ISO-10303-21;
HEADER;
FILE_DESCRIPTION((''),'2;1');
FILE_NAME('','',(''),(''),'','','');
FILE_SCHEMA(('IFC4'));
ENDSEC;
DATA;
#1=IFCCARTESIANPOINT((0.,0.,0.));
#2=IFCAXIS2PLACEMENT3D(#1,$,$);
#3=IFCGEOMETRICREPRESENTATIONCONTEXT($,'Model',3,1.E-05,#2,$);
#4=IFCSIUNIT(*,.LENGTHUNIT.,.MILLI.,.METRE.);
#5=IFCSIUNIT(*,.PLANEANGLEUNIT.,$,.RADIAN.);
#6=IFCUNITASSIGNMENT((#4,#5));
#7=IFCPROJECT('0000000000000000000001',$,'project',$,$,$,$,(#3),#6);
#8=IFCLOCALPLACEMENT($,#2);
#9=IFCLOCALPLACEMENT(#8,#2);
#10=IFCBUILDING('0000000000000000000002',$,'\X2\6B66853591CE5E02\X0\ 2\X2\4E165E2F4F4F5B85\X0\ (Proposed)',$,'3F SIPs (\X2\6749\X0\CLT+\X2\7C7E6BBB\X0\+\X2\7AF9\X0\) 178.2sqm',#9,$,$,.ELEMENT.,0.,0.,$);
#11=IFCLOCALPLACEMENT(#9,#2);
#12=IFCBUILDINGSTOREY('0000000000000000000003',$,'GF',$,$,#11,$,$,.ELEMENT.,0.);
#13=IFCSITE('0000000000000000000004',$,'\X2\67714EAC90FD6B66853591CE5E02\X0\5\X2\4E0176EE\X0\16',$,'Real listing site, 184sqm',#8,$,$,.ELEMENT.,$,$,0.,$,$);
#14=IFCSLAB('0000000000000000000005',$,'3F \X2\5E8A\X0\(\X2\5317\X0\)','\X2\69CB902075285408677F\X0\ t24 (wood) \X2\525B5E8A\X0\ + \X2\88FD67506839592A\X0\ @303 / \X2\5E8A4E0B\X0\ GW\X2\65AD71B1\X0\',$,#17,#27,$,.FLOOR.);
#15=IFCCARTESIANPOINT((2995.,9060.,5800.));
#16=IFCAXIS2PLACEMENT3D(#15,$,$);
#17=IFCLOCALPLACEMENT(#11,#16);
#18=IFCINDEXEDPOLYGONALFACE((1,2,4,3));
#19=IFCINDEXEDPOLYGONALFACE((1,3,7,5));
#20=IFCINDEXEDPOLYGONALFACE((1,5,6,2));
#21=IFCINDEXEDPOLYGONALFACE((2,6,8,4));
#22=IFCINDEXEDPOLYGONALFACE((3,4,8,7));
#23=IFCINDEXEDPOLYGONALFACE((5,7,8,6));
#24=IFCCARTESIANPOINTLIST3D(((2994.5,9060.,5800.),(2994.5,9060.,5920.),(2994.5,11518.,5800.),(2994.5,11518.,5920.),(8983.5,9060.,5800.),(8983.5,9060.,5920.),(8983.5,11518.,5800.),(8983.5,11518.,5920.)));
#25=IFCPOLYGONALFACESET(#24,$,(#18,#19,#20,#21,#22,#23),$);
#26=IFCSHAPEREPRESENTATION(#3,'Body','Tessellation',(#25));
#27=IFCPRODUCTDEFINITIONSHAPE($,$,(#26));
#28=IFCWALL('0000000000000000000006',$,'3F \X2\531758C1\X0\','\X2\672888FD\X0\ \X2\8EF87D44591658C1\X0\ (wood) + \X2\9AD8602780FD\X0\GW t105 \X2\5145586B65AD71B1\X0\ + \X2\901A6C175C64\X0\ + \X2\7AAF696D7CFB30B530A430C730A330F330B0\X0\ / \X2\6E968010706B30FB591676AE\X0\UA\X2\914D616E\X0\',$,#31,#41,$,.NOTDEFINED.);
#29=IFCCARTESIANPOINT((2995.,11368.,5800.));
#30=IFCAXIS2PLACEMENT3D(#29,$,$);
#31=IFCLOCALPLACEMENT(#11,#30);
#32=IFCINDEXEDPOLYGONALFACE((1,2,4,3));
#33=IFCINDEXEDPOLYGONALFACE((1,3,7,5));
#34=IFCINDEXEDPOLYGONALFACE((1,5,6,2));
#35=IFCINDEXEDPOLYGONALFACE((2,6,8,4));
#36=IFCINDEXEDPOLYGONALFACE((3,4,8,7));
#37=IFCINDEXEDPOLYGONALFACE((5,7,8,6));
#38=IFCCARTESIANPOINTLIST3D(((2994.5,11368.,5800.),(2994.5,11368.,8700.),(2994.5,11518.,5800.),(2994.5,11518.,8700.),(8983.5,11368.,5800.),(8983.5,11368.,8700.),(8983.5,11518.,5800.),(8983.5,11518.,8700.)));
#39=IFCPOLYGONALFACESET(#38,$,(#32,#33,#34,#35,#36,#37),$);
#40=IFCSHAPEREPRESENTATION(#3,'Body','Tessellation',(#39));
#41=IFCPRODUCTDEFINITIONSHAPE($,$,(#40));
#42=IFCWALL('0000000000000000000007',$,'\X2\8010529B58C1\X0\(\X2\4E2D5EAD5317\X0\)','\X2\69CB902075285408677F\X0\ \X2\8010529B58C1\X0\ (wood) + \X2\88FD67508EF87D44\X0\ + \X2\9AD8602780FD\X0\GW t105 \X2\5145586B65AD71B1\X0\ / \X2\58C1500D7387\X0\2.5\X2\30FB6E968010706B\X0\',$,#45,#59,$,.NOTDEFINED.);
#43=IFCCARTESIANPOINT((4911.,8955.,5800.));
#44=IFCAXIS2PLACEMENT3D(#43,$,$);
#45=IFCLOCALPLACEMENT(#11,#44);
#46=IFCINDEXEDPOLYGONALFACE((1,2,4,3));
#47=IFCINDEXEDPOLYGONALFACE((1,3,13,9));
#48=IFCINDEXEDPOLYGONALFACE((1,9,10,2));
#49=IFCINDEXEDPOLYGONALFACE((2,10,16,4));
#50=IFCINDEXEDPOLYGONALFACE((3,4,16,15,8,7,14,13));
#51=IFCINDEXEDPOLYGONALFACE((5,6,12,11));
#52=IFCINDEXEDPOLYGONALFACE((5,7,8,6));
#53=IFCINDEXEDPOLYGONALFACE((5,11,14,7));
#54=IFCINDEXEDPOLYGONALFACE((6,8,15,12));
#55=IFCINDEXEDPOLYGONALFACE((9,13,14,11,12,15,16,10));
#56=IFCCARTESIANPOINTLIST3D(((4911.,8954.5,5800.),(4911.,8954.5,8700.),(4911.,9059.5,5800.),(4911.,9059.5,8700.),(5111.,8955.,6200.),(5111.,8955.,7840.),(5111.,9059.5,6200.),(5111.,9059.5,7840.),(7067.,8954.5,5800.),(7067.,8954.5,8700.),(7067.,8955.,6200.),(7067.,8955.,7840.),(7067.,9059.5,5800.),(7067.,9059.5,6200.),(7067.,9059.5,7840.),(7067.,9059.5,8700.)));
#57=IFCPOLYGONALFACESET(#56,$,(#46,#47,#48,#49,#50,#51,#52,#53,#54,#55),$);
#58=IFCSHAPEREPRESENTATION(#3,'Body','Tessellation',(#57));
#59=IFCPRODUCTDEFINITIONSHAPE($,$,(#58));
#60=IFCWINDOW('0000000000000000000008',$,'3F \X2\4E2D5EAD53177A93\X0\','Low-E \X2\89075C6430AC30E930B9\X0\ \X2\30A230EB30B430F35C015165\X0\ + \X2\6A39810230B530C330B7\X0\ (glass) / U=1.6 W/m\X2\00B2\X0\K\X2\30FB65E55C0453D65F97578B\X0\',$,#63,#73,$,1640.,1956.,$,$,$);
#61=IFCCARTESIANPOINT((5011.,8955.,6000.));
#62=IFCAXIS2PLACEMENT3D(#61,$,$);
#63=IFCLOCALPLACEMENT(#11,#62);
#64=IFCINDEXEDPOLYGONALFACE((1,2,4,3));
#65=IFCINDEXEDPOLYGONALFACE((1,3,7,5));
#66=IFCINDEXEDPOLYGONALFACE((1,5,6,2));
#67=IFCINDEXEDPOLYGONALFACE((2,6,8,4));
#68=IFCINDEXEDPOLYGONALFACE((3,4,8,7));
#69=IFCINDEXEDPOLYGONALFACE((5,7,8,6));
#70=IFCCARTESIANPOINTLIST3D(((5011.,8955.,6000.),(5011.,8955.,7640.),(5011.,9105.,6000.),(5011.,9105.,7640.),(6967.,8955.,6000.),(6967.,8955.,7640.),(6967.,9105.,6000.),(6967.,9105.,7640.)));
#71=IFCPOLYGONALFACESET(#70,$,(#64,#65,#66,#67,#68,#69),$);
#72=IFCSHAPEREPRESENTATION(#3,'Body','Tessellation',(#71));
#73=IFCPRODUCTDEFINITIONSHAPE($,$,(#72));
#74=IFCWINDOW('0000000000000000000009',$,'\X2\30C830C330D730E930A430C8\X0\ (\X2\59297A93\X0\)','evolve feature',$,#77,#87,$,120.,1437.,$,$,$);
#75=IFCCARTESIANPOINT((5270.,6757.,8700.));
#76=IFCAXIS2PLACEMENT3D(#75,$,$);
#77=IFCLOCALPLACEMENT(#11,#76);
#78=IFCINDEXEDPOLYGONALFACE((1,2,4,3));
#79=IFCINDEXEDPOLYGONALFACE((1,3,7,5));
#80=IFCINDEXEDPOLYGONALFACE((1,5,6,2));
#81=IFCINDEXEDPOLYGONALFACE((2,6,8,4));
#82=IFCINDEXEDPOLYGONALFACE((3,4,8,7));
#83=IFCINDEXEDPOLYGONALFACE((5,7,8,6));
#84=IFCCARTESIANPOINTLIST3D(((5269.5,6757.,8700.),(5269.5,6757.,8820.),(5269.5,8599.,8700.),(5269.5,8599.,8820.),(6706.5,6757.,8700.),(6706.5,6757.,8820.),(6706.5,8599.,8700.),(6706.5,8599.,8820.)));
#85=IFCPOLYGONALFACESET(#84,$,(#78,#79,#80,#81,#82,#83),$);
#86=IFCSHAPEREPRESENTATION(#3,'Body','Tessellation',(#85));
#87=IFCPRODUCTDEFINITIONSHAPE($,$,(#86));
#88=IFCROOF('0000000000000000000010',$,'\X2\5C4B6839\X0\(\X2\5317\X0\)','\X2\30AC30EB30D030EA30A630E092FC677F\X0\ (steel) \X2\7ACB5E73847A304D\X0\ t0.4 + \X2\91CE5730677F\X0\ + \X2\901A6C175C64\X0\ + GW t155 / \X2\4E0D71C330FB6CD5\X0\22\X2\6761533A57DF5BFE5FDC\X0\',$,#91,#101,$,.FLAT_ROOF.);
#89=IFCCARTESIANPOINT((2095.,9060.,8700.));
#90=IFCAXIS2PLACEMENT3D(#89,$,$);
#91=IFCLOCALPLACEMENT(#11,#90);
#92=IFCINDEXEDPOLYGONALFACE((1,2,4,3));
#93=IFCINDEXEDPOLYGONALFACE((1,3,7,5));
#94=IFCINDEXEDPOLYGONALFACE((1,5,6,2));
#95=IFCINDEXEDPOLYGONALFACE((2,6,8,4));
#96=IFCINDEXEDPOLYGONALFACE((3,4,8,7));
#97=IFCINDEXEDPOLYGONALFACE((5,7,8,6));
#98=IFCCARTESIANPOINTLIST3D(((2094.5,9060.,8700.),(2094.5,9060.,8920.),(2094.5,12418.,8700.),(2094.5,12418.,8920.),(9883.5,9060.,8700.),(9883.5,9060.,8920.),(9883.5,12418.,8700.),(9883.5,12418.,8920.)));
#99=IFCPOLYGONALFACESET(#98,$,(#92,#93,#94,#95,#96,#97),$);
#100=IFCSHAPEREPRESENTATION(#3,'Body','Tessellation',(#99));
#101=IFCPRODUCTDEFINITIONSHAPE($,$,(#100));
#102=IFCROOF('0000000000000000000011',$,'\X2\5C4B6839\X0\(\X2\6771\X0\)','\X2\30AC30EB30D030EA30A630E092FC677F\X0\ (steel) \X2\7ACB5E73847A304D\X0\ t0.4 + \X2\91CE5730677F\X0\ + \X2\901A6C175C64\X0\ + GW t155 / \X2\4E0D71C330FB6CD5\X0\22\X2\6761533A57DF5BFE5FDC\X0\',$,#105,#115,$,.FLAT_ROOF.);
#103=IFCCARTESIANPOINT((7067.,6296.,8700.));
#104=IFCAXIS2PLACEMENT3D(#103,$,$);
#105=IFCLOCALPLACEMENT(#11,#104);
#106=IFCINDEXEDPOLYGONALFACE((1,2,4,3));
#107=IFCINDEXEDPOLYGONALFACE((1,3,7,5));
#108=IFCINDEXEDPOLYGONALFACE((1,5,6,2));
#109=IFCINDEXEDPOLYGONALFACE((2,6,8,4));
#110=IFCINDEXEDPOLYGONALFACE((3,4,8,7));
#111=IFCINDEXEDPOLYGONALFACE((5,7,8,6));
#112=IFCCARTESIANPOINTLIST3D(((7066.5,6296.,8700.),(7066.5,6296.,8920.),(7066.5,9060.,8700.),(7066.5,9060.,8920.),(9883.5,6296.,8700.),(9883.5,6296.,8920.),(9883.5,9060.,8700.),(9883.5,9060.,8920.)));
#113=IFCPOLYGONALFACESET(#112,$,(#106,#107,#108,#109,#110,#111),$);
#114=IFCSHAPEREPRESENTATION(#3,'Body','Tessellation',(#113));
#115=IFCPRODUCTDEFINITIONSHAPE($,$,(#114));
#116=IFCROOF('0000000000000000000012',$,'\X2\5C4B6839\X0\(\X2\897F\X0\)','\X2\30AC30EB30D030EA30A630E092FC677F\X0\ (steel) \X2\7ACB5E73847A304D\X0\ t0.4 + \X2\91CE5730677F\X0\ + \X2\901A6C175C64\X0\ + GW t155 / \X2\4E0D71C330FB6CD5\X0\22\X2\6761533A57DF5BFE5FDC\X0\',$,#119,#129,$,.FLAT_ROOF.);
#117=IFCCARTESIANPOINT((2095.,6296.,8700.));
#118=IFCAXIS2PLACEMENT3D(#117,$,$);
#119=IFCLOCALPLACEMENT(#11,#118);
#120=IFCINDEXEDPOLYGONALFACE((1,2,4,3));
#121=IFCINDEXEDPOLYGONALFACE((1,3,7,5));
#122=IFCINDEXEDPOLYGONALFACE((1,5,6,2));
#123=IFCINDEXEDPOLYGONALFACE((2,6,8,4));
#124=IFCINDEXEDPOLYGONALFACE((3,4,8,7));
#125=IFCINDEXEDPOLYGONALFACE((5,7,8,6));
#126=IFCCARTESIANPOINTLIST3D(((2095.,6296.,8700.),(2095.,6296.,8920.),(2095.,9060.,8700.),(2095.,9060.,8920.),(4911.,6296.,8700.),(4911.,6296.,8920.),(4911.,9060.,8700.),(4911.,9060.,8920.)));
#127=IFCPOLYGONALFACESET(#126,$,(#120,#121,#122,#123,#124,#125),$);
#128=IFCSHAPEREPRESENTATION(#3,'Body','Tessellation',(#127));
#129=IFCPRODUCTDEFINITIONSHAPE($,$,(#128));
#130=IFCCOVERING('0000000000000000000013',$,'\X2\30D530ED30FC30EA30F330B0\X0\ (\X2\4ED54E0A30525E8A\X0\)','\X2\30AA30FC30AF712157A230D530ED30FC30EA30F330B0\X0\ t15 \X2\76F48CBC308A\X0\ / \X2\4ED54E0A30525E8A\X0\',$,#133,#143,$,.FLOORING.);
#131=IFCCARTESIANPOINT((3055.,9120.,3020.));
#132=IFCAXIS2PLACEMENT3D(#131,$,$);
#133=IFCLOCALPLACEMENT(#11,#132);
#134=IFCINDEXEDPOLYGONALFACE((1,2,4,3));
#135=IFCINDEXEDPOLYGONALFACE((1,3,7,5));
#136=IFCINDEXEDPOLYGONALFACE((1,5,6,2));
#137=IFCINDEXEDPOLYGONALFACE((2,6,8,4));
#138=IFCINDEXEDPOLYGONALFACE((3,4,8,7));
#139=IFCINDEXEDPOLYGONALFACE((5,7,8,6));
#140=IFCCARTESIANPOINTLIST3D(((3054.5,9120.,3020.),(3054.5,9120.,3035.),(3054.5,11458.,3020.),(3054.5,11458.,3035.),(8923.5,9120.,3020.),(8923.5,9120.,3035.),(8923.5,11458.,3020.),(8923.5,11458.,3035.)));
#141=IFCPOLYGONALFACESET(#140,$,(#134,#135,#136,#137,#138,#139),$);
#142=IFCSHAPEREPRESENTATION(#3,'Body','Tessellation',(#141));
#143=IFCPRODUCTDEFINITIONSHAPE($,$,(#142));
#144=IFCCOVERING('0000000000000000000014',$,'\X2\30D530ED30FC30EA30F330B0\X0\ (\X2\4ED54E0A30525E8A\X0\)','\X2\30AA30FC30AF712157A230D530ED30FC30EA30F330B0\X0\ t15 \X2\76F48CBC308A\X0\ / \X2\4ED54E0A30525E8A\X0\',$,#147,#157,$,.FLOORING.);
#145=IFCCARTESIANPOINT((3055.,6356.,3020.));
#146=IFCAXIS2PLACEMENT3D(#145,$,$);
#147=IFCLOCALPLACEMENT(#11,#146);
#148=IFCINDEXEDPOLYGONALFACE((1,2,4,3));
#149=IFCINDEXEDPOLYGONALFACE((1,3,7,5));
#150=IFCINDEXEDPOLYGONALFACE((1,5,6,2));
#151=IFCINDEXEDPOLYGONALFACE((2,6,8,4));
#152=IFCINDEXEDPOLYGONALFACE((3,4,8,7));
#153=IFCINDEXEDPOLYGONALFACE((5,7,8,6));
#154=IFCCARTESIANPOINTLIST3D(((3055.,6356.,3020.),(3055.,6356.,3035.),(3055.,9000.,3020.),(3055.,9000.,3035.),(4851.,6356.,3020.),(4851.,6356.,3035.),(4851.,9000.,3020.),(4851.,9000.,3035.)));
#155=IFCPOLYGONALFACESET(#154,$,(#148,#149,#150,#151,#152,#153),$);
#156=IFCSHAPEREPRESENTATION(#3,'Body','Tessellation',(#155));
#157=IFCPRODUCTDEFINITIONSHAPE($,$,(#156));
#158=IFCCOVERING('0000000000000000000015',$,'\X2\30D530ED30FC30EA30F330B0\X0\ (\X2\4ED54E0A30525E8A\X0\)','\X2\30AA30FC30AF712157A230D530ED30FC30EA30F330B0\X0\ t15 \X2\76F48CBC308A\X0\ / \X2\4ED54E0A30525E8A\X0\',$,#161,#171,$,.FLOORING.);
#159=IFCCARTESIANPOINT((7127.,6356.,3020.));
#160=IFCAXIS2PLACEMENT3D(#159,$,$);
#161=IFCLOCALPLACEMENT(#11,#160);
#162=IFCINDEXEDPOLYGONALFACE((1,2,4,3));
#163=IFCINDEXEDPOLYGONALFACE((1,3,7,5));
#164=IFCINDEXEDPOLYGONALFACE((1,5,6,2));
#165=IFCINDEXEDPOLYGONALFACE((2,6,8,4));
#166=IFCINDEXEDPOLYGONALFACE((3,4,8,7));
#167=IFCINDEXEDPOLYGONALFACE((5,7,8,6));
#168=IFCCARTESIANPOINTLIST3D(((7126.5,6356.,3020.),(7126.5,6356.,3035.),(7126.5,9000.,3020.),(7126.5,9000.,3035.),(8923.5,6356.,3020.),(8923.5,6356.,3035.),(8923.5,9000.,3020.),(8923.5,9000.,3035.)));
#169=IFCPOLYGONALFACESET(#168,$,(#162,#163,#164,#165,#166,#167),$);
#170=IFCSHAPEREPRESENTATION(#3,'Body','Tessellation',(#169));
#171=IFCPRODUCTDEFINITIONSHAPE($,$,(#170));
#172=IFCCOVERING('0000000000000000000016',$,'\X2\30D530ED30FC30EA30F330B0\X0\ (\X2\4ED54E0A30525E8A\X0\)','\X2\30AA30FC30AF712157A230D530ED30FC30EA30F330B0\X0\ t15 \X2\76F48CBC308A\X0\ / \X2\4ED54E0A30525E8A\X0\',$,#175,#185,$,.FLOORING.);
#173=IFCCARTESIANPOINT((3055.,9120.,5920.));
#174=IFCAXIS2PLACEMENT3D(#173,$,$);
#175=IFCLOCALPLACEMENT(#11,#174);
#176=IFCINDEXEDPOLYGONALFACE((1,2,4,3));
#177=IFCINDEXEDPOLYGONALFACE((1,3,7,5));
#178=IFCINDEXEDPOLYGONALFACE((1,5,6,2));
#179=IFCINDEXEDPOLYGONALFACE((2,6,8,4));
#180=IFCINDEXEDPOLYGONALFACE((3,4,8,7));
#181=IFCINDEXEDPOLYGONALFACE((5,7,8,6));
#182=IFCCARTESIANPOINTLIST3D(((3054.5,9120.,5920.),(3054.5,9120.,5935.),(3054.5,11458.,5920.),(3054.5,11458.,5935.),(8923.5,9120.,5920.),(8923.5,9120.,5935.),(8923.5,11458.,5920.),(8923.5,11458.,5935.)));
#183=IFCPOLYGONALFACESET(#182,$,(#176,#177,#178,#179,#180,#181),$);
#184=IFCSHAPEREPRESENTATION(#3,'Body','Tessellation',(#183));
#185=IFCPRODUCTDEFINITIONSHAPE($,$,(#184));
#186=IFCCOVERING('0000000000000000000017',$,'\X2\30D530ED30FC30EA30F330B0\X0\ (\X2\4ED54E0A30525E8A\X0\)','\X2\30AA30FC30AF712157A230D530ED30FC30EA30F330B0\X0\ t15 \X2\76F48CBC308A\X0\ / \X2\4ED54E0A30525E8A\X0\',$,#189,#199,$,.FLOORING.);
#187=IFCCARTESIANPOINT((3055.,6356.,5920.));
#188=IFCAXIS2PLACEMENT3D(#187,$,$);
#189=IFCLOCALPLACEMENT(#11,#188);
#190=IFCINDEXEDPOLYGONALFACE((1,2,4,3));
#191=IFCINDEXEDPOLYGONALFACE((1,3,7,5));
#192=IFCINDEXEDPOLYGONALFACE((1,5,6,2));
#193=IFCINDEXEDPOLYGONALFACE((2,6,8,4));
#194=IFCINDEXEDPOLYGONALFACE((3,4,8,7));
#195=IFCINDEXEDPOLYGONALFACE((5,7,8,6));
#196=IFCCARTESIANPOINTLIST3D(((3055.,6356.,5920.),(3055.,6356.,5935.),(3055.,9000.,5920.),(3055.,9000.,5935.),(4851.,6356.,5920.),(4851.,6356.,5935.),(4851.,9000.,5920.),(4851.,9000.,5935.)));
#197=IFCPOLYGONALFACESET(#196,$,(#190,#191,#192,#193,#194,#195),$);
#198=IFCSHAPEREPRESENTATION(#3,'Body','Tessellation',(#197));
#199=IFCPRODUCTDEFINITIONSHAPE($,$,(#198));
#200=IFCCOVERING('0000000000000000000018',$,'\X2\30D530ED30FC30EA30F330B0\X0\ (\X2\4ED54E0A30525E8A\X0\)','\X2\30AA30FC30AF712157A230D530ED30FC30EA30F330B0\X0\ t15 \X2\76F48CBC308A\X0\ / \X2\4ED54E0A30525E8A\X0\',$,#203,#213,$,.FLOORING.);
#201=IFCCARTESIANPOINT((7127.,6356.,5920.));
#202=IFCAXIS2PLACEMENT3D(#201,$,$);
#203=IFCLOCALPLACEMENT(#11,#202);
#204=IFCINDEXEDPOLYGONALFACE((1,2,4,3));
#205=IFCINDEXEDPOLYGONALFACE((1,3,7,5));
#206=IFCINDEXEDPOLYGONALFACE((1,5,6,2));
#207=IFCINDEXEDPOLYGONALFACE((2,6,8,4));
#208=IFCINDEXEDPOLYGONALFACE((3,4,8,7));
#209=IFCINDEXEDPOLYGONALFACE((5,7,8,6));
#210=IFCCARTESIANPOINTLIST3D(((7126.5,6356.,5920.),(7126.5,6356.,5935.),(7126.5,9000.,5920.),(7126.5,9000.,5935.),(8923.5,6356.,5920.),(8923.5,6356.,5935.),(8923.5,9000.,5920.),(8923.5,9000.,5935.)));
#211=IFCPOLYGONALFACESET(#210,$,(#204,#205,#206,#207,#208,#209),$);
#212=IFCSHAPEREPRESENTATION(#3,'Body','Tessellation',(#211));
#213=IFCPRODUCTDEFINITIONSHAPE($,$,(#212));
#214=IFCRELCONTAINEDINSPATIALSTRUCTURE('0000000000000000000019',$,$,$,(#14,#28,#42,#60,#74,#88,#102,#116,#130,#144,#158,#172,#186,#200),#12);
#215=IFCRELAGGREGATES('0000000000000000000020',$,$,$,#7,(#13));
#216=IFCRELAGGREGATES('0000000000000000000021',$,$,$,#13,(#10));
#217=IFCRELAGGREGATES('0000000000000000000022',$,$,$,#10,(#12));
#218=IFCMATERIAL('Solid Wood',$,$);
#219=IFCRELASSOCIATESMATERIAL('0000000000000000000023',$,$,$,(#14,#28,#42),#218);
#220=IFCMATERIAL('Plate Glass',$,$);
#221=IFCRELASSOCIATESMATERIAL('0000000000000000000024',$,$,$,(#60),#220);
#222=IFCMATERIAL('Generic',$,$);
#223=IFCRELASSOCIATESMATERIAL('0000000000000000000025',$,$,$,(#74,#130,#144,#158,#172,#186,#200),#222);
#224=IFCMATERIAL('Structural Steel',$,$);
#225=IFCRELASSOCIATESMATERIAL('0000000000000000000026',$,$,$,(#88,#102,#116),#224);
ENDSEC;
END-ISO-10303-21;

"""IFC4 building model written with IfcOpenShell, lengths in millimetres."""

from ifc_helpers import new_model, si_unit, frame, frame_2d, origin, place, context, project, spatial, rectangle, extrude, material, element, fill, save


model = new_model("IFC4")

# Units and contexts
model_context = context("Model", 3, precision=1e-05, world=origin())
ifc_project = project(units=[si_unit("LENGTHUNIT", "METRE", prefix="MILLI"), si_unit("PLANEANGLEUNIT", "RADIAN")], contexts=[model_context])

# Site, building, storey
site_placement = place(None, origin())
site = spatial("IfcSite", under=ifc_project, at=site_placement, Name="東京都武蔵野市5丁目16", ObjectType="Real listing site, 184sqm", CompositionType="ELEMENT", RefElevation=0.0)
building_placement = place(site_placement, origin())
building = spatial("IfcBuilding", under=site, at=building_placement, Name="武蔵野市 2世帯住宅 (Proposed)", ObjectType="3F SIPs (杉CLT+籾殻+竹) 178.2sqm", CompositionType="ELEMENT", ElevationOfRefHeight=0.0, ElevationOfTerrain=0.0)
storey_placement = place(building_placement, origin())
storey = spatial("IfcBuildingStorey", under=building, at=storey_placement, Name="GF", CompositionType="ELEMENT", Elevation=0.0)

# Slab
ifc_material_1 = material(Name="Solid Wood")
slab_placement = place(storey_placement, frame((2995.0, 9060.0, 5800.0)))
element("IfcSlab", 1, at=slab_placement, inside=storey, material=ifc_material_1, Name="3F 床(北)", Description="構造用合板 t24 (wood) 剛床 + 製材根太 @303 / 床下 GW断熱", PredefinedType="FLOOR", context=model_context, shape_type="SweptSolid", body=[
    extrude(rectangle(XDim=5989.0, YDim=2458.0, at=frame_2d((2994.0, 1229.0))), frame((2995.0, 9060.0, 5800.0)), (0.0, 0.0, 1.0), 120.0),
])

# Wall
wall_1_placement = place(storey_placement, frame((2995.0, 11368.0, 5800.0)))
element("IfcWall", 2, at=wall_1_placement, inside=storey, material=ifc_material_1, Name="3F 北壁", Description="木製 軸組外壁 (wood) + 高性能GW t105 充填断熱 + 通気層 + 窯業系サイディング / 準耐火・外皮UA配慮", PredefinedType="NOTDEFINED", context=model_context, shape_type="SweptSolid", body=[
    extrude(rectangle(XDim=5989.0, YDim=150.0, at=frame_2d((2994.0, 75.0))), frame((2995.0, 11368.0, 5800.0)), (0.0, 0.0, 1.0), 2900.0),
])

# Wall, opening, window
wall_2_placement = place(storey_placement, frame((4911.0, 8955.0, 5800.0)))
wall_2 = element("IfcWall", 3, at=wall_2_placement, inside=storey, material=ifc_material_1, Name="耐力壁(中庭北)", Description="構造用合板 耐力壁 (wood) + 製材軸組 + 高性能GW t105 充填断熱 / 壁倍率2.5・準耐火", PredefinedType="NOTDEFINED", context=model_context, shape_type="SweptSolid", body=[
    extrude(rectangle(XDim=2156.0, YDim=105.0, at=frame_2d((1078.0, 52.0))), frame((4911.0, 8955.0, 5800.0)), (0.0, 0.0, 1.0), 2900.0),
])
opening_placement = place(storey_placement, frame((5011.0, 8955.0, 6000.0)))
opening = element("IfcOpeningElement", 4, at=opening_placement, cuts=wall_2, PredefinedType="NOTDEFINED", context=model_context, shape_type="SweptSolid", body=[
    extrude(rectangle(XDim=1956.0, YDim=150.0, at=frame_2d((978.0, 75.0))), frame((5011.0, 8955.0, 6000.0)), (0.0, 0.0, 1.0), 1640.0),
])
ifc_material_2 = material(Name="Plate Glass")
window_1_placement = place(storey_placement, frame((5011.0, 8955.0, 6000.0)))
window_1 = element("IfcWindow", 5, at=window_1_placement, inside=storey, material=ifc_material_2, Name="3F 中庭北窓", Description="Low-E 複層ガラス アルゴン封入 + 樹脂サッシ (glass) / U=1.6 W/m²K・日射取得型", OverallHeight=1640.0, OverallWidth=1956.0, context=model_context, shape_type="SweptSolid", body=[
    extrude(rectangle(XDim=1956.0, YDim=150.0, at=frame_2d((978.0, 75.0))), frame((5011.0, 8955.0, 6000.0)), (0.0, 0.0, 1.0), 1640.0),
])
fill(opening, window_1)

# Window
ifc_material_3 = material(Name="Generic")
window_2_placement = place(storey_placement, frame((5270.0, 6757.0, 8700.0)))
element("IfcWindow", 6, at=window_2_placement, inside=storey, material=ifc_material_3, Name="トップライト (天窓)", Description="evolve feature", OverallHeight=120.0, OverallWidth=1437.0, context=model_context, shape_type="SweptSolid", body=[
    extrude(rectangle(XDim=1437.0, YDim=1842.0, at=frame_2d((718.0, 921.0))), frame((5270.0, 6757.0, 8700.0)), (0.0, 0.0, 1.0), 120.0),
])

# Roofs
ifc_material_4 = material(Name="Structural Steel")
roof_1_placement = place(storey_placement, frame((2095.0, 9060.0, 8700.0)))
element("IfcRoof", 7, at=roof_1_placement, inside=storey, material=ifc_material_4, Name="屋根(北)", Description="ガルバリウム鋼板 (steel) 立平葺き t0.4 + 野地板 + 通気層 + GW t155 / 不燃・法22条区域対応", PredefinedType="FLAT_ROOF", context=model_context, shape_type="SweptSolid", body=[
    extrude(rectangle(XDim=7789.0, YDim=3358.0, at=frame_2d((3894.0, 1679.0))), frame((2095.0, 9060.0, 8700.0)), (0.0, 0.0, 1.0), 220.0),
])
roof_2_placement = place(storey_placement, frame((7067.0, 6296.0, 8700.0)))
element("IfcRoof", 8, at=roof_2_placement, inside=storey, material=ifc_material_4, Name="屋根(東)", Description="ガルバリウム鋼板 (steel) 立平葺き t0.4 + 野地板 + 通気層 + GW t155 / 不燃・法22条区域対応", PredefinedType="FLAT_ROOF", context=model_context, shape_type="SweptSolid", body=[
    extrude(rectangle(XDim=2817.0, YDim=2764.0, at=frame_2d((1408.0, 1382.0))), frame((7067.0, 6296.0, 8700.0)), (0.0, 0.0, 1.0), 220.0),
])
roof_3_placement = place(storey_placement, frame((2095.0, 6296.0, 8700.0)))
element("IfcRoof", 9, at=roof_3_placement, inside=storey, material=ifc_material_4, Name="屋根(西)", Description="ガルバリウム鋼板 (steel) 立平葺き t0.4 + 野地板 + 通気層 + GW t155 / 不燃・法22条区域対応", PredefinedType="FLAT_ROOF", context=model_context, shape_type="SweptSolid", body=[
    extrude(rectangle(XDim=2816.0, YDim=2764.0, at=frame_2d((1408.0, 1382.0))), frame((2095.0, 6296.0, 8700.0)), (0.0, 0.0, 1.0), 220.0),
])

# Coverings
covering_1_placement = place(storey_placement, frame((3055.0, 9120.0, 3020.0)))
element("IfcCovering", 10, at=covering_1_placement, inside=storey, material=ifc_material_3, Name="フローリング (仕上げ床)", Description="オーク無垢フローリング t15 直貼り / 仕上げ床", PredefinedType="FLOORING", context=model_context, shape_type="SweptSolid", body=[
    extrude(rectangle(XDim=5869.0, YDim=2338.0, at=frame_2d((2934.0, 1169.0))), frame((3055.0, 9120.0, 3020.0)), (0.0, 0.0, 1.0), 15.0),
])
covering_2_placement = place(storey_placement, frame((3055.0, 6356.0, 3020.0)))
element("IfcCovering", 11, at=covering_2_placement, inside=storey, material=ifc_material_3, Name="フローリング (仕上げ床)", Description="オーク無垢フローリング t15 直貼り / 仕上げ床", PredefinedType="FLOORING", context=model_context, shape_type="SweptSolid", body=[
    extrude(rectangle(XDim=1796.0, YDim=2644.0, at=frame_2d((898.0, 1322.0))), frame((3055.0, 6356.0, 3020.0)), (0.0, 0.0, 1.0), 15.0),
])
covering_3_placement = place(storey_placement, frame((7127.0, 6356.0, 3020.0)))
element("IfcCovering", 12, at=covering_3_placement, inside=storey, material=ifc_material_3, Name="フローリング (仕上げ床)", Description="オーク無垢フローリング t15 直貼り / 仕上げ床", PredefinedType="FLOORING", context=model_context, shape_type="SweptSolid", body=[
    extrude(rectangle(XDim=1797.0, YDim=2644.0, at=frame_2d((898.0, 1322.0))), frame((7127.0, 6356.0, 3020.0)), (0.0, 0.0, 1.0), 15.0),
])
covering_4_placement = place(storey_placement, frame((3055.0, 9120.0, 5920.0)))
element("IfcCovering", 13, at=covering_4_placement, inside=storey, material=ifc_material_3, Name="フローリング (仕上げ床)", Description="オーク無垢フローリング t15 直貼り / 仕上げ床", PredefinedType="FLOORING", context=model_context, shape_type="SweptSolid", body=[
    extrude(rectangle(XDim=5869.0, YDim=2338.0, at=frame_2d((2934.0, 1169.0))), frame((3055.0, 9120.0, 5920.0)), (0.0, 0.0, 1.0), 15.0),
])
covering_5_placement = place(storey_placement, frame((3055.0, 6356.0, 5920.0)))
element("IfcCovering", 14, at=covering_5_placement, inside=storey, material=ifc_material_3, Name="フローリング (仕上げ床)", Description="オーク無垢フローリング t15 直貼り / 仕上げ床", PredefinedType="FLOORING", context=model_context, shape_type="SweptSolid", body=[
    extrude(rectangle(XDim=1796.0, YDim=2644.0, at=frame_2d((898.0, 1322.0))), frame((3055.0, 6356.0, 5920.0)), (0.0, 0.0, 1.0), 15.0),
])
covering_6_placement = place(storey_placement, frame((7127.0, 6356.0, 5920.0)))
element("IfcCovering", 15, at=covering_6_placement, inside=storey, material=ifc_material_3, Name="フローリング (仕上げ床)", Description="オーク無垢フローリング t15 直貼り / 仕上げ床", PredefinedType="FLOORING", context=model_context, shape_type="SweptSolid", body=[
    extrude(rectangle(XDim=1797.0, YDim=2644.0, at=frame_2d((898.0, 1322.0))), frame((7127.0, 6356.0, 5920.0)), (0.0, 0.0, 1.0), 15.0),
])

save(model, "model.ifc")
